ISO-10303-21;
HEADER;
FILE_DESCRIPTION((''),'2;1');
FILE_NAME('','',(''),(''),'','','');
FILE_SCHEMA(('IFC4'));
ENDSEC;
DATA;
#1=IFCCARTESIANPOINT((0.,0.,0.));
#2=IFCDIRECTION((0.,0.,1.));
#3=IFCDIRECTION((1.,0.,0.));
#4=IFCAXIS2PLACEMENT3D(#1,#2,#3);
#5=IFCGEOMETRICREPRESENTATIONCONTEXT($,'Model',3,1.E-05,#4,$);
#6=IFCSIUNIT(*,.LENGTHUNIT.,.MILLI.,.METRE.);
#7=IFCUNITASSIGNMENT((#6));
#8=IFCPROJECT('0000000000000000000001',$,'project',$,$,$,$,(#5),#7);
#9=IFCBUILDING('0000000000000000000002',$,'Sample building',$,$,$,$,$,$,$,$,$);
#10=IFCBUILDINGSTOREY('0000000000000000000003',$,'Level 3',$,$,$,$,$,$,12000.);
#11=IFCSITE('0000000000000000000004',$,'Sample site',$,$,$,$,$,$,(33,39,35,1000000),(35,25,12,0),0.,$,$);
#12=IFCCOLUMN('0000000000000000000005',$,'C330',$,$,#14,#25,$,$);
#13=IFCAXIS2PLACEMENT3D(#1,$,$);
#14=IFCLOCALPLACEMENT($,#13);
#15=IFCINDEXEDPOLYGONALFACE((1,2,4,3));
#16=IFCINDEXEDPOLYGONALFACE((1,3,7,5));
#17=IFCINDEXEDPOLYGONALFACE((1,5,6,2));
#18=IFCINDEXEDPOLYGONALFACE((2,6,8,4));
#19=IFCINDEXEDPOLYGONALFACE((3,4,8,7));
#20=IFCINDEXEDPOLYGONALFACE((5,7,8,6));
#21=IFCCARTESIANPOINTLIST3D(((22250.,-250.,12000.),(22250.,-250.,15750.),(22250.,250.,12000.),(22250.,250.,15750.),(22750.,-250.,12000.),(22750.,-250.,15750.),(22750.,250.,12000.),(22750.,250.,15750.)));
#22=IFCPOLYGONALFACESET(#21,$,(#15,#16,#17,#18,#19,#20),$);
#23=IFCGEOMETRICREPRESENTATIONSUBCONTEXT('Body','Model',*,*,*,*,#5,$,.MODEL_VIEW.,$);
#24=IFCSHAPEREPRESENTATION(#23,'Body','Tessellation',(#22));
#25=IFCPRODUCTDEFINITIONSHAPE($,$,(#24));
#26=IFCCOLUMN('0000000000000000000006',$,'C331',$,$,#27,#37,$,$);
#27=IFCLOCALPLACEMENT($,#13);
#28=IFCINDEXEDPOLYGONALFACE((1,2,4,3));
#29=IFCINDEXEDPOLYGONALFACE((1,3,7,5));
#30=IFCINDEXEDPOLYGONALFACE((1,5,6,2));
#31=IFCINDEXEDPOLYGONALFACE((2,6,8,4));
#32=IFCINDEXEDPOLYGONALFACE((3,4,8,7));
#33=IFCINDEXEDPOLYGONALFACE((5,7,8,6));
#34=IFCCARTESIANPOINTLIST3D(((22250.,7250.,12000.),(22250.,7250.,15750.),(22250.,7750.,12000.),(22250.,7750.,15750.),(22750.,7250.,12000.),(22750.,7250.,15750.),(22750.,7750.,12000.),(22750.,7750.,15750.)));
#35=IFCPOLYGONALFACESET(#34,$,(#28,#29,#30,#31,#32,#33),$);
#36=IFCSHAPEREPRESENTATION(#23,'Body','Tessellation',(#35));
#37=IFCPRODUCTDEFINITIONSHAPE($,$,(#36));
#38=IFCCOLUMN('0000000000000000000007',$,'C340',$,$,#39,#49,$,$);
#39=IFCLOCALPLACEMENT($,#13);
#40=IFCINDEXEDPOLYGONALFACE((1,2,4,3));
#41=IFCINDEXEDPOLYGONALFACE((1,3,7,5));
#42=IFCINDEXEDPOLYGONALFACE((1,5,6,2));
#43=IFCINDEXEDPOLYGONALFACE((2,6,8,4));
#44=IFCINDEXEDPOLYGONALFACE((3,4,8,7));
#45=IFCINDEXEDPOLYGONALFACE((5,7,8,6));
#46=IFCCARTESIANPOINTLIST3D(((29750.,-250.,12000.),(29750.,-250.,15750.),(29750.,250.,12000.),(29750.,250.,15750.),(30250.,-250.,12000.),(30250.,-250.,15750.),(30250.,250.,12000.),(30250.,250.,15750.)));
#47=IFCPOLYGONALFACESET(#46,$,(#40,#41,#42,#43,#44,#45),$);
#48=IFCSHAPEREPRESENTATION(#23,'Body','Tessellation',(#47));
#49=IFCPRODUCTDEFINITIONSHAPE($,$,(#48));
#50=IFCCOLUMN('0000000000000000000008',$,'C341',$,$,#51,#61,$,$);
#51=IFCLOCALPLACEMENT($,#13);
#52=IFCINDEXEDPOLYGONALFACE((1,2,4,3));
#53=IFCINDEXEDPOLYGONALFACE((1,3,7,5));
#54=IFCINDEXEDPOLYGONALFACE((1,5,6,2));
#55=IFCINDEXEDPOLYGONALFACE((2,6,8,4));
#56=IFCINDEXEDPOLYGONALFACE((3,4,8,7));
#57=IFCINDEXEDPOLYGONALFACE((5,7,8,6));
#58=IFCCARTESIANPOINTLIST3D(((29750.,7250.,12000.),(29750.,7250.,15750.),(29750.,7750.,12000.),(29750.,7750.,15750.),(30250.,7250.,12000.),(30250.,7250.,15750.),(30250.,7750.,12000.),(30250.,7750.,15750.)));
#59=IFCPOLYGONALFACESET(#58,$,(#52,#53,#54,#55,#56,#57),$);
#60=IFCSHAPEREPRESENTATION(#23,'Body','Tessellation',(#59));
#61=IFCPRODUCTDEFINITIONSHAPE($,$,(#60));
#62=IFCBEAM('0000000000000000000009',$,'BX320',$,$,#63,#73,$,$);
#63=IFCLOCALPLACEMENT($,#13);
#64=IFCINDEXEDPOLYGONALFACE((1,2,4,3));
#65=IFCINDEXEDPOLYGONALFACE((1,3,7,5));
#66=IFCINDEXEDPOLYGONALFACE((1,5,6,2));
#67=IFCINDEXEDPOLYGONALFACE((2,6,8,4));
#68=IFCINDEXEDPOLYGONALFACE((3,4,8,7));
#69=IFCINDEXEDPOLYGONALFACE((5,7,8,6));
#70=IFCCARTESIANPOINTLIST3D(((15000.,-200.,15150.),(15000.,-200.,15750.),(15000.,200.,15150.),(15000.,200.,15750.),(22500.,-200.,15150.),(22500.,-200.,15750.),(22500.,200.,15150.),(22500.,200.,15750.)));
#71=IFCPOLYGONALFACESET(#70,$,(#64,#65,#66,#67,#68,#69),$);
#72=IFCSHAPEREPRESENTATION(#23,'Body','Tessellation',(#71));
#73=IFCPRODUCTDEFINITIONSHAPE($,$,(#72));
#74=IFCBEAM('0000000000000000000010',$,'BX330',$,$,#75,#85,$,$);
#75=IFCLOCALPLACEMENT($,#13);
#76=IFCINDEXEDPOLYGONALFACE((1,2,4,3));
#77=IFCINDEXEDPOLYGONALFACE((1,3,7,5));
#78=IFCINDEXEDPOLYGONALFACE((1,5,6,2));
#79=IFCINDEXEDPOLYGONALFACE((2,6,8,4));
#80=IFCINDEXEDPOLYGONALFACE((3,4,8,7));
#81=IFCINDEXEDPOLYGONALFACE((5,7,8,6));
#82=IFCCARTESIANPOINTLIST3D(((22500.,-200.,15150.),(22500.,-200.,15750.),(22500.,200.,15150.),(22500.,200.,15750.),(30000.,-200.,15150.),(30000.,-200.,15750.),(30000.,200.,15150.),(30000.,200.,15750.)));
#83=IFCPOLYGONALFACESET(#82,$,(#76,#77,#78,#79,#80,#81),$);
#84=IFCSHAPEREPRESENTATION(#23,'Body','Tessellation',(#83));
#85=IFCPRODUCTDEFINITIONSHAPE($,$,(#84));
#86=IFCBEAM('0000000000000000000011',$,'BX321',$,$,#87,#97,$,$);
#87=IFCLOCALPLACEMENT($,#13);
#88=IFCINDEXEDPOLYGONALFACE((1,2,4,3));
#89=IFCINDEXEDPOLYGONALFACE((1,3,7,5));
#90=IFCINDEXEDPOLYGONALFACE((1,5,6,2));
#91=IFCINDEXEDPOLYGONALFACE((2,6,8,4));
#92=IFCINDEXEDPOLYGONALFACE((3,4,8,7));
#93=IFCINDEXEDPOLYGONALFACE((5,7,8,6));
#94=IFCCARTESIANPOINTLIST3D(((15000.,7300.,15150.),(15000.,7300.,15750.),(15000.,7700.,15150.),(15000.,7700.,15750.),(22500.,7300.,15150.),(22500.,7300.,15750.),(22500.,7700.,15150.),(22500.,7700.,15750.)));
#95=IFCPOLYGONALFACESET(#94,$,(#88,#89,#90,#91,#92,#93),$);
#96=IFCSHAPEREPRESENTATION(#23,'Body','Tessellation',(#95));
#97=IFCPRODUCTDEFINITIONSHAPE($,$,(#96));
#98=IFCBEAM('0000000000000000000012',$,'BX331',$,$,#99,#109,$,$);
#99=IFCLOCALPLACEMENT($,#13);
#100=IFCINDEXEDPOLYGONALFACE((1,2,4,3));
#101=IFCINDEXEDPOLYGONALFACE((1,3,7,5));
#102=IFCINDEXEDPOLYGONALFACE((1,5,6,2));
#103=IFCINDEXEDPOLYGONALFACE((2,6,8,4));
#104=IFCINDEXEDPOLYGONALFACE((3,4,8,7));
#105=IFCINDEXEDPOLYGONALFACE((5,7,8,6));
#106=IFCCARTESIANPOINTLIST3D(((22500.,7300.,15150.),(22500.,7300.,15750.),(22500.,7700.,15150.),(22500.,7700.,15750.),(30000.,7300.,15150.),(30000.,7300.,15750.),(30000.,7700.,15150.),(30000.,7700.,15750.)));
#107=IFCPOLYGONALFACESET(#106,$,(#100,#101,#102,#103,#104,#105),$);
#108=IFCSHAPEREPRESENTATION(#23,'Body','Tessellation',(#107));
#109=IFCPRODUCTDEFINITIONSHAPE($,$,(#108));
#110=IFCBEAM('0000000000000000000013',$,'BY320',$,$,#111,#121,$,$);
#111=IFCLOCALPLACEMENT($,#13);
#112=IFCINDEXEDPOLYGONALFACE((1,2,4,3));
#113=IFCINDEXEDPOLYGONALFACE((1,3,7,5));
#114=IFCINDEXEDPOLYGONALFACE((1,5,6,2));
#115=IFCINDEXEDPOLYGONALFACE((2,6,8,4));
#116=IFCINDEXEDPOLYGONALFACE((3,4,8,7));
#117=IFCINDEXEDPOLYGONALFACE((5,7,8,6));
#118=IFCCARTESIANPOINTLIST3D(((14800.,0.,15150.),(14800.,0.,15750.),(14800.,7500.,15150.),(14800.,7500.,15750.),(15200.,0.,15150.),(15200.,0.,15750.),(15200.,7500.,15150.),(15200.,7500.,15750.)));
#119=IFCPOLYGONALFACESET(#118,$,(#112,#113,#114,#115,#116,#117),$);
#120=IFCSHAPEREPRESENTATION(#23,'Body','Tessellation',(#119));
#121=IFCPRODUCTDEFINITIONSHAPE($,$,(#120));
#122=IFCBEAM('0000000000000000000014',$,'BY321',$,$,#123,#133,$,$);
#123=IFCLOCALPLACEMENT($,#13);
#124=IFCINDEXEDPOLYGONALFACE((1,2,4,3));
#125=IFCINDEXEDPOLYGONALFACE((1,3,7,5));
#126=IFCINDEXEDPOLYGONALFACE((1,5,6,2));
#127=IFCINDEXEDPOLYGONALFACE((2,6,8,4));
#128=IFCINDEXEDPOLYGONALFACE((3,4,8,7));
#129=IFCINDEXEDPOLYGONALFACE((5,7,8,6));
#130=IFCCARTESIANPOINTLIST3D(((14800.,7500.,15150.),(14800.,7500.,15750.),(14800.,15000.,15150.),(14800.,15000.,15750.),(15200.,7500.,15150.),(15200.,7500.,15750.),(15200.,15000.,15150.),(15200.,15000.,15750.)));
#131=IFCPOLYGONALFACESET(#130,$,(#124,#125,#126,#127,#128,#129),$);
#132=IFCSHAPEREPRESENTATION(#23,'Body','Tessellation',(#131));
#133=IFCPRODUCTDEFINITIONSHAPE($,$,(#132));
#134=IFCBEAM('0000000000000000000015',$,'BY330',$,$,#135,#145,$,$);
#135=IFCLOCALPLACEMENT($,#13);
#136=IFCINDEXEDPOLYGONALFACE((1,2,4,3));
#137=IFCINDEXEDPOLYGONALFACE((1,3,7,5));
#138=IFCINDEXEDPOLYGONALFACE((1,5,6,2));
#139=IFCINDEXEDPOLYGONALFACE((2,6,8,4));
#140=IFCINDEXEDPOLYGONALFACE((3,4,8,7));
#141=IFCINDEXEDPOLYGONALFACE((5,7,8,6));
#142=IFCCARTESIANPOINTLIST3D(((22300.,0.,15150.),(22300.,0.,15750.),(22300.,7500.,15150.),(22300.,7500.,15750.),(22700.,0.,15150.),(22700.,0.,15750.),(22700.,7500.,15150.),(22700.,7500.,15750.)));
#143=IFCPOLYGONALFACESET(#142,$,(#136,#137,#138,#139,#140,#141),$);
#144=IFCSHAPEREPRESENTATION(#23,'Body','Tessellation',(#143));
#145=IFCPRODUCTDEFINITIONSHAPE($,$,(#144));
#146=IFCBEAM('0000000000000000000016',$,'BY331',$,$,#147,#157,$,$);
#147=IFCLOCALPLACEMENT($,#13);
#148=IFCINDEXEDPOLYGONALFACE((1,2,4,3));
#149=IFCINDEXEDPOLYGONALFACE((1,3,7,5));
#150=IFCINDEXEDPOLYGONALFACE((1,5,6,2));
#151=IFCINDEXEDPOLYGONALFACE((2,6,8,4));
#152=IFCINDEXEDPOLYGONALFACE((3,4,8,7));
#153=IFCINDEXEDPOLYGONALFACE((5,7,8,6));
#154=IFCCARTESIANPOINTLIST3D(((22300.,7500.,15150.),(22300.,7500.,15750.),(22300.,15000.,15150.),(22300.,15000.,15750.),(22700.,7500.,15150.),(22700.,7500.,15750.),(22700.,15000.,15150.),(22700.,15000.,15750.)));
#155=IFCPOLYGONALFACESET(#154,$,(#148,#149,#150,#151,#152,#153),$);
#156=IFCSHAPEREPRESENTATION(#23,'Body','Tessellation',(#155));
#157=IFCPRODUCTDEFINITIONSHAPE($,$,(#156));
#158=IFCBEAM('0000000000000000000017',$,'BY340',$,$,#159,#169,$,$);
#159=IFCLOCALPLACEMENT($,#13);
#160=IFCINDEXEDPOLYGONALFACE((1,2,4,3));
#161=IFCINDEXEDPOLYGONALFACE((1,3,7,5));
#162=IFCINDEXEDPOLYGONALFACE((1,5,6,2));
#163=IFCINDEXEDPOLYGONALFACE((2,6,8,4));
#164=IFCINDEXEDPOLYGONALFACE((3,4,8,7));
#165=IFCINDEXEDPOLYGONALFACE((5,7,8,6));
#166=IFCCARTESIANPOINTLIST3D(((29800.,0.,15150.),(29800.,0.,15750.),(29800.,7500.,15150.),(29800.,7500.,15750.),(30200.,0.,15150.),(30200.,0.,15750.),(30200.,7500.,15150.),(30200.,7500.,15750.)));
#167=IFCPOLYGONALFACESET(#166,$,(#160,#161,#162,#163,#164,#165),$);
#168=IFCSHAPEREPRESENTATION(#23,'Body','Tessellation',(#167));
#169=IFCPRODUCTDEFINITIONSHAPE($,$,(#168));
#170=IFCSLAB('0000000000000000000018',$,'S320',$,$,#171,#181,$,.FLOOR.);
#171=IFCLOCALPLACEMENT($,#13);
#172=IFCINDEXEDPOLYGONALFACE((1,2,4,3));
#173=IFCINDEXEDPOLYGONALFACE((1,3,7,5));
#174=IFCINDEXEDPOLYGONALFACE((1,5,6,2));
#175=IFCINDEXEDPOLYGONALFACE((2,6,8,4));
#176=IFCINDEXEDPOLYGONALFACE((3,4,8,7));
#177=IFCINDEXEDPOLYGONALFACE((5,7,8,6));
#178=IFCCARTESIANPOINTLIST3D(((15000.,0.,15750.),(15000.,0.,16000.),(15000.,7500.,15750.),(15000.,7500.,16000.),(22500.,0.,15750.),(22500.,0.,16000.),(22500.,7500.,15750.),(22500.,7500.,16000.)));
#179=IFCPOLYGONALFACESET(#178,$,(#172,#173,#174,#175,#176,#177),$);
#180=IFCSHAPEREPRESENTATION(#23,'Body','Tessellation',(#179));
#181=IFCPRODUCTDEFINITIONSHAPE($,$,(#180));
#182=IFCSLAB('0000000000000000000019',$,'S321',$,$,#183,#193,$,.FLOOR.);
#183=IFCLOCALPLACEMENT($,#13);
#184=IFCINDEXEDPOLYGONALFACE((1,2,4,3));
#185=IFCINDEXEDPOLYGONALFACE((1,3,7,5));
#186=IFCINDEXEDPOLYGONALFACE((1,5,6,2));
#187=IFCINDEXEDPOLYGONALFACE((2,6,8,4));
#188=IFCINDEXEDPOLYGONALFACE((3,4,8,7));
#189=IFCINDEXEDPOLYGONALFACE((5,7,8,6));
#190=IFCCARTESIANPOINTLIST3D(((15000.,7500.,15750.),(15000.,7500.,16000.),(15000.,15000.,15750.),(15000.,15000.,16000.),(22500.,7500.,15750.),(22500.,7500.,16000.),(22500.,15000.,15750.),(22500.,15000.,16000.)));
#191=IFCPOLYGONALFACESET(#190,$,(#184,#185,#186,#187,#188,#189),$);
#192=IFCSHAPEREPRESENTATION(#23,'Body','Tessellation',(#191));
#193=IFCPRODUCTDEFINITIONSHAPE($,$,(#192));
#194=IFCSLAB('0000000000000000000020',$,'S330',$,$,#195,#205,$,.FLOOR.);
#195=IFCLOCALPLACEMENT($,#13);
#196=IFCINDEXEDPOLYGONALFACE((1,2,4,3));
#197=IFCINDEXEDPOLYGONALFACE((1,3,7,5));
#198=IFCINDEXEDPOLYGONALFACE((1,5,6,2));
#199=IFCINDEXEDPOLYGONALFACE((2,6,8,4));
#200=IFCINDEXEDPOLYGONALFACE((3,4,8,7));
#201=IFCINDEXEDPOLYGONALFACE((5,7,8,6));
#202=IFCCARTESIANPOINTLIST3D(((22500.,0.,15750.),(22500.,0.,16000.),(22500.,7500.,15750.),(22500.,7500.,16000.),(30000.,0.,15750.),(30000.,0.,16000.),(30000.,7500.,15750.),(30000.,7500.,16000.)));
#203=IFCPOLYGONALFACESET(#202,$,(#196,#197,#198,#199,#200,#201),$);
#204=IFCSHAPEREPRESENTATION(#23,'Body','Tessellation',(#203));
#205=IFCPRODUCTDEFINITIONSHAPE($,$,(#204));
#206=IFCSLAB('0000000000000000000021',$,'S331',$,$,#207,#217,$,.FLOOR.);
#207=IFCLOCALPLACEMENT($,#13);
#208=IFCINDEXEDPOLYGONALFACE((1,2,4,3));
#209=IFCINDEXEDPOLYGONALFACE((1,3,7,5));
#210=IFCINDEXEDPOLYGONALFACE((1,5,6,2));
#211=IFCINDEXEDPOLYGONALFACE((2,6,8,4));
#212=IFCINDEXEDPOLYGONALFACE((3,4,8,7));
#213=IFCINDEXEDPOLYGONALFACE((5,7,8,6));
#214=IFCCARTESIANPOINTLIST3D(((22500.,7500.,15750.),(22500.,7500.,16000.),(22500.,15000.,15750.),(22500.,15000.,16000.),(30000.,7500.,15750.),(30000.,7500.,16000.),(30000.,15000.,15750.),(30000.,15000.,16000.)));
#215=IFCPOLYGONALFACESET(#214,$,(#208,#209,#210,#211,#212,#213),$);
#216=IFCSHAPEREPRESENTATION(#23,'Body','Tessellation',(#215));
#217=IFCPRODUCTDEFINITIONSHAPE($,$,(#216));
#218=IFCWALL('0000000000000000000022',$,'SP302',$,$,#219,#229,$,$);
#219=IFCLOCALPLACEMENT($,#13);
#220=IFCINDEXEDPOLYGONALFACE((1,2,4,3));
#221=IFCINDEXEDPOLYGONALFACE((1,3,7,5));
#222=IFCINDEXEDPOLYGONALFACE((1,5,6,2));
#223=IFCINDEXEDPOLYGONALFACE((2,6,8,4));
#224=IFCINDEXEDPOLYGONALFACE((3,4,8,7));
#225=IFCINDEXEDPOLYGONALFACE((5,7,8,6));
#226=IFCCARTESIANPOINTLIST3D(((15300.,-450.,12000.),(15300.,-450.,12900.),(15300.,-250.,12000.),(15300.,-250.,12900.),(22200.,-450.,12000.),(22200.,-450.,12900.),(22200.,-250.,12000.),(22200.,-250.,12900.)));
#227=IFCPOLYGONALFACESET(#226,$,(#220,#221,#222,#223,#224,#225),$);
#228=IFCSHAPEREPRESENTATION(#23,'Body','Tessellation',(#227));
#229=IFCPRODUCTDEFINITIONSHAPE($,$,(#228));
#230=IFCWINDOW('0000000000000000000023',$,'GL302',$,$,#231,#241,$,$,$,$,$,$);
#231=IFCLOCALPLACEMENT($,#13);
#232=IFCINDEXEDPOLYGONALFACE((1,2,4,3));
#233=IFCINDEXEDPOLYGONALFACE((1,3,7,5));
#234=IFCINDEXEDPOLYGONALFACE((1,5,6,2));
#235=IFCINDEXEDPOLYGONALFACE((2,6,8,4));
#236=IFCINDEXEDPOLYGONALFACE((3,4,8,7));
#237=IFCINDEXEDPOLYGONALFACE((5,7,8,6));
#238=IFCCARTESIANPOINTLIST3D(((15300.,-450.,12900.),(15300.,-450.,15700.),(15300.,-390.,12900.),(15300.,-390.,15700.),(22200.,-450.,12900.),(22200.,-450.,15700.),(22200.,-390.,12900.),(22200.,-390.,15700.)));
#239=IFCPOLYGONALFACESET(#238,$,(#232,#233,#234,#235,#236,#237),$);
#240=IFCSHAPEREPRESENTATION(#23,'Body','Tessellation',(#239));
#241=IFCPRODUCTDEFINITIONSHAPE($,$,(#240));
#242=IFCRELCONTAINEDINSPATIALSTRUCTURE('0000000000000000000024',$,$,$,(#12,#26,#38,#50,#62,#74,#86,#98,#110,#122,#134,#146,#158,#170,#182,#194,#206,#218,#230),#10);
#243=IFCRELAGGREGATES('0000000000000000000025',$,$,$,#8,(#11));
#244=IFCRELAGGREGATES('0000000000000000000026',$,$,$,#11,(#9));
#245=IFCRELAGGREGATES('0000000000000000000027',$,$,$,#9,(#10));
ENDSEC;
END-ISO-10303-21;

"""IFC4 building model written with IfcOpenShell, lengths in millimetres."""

from ifc_helpers import new_model, si_unit, frame, origin_with_axes, place, context, subcontext, project, spatial, indexed_curve, outline, extrude, element, save


model = new_model("IFC4")

# Units and contexts
model_context = context("Model", 3, precision=1e-05, world=origin_with_axes())
body_context = subcontext(model_context, "Body", "Model", "MODEL_VIEW")
ifc_project = project(units=[si_unit("LENGTHUNIT", "METRE", prefix="MILLI")], contexts=[model_context])

# Site, building, storey
site = spatial("IfcSite", under=ifc_project, Name="Sample site", RefLatitude=(33, 39, 35, 1000000), RefLongitude=(35, 25, 12, 0), RefElevation=0.0)
building = spatial("IfcBuilding", under=site, Name="Sample building")
storey = spatial("IfcBuildingStorey", under=building, Name="Level 3", Elevation=12000.0)

# Columns
for number, where, z_axis, x_axis, name in (
    (1, (22250.0, -250.0, 12000.0), (0.0, 0.0, 1.0), (1.0, 0.0, 0.0), "C330"),
    (2, (22250.0, 7250.0, 12000.0), (0.0, 0.0, 1.0), (1.0, 0.0, 0.0), "C331"),
    (3, (29750.0, -250.0, 12000.0), (0.0, 0.0, 1.0), (1.0, 0.0, 0.0), "C340"),
    (4, (29750.0, 7250.0, 12000.0), (0.0, 0.0, 1.0), (1.0, 0.0, 0.0), "C341"),
):
    element("IfcColumn", number, at=place(None, frame(where, z_axis=z_axis, x_axis=x_axis)), inside=storey, Name=name, context=body_context, shape_type="SweptSolid", body=[
        extrude(outline(indexed_curve([(0.0, 0.0), (0.0, 500.0), (500.0, 500.0), (500.0, 0.0), (0.0, 0.0)], self_intersect=False)), origin_with_axes(), (0.0, 0.0, 1.0), 3750.0),
    ])

# Beams
for number, where, z_axis, x_axis, name in (
    (5, (15000.0, -200.0, 15150.0), (0.0, 0.0, 1.0), (1.0, 0.0, 0.0), "BX320"),
    (6, (22500.0, -200.0, 15150.0), (0.0, 0.0, 1.0), (1.0, 0.0, 0.0), "BX330"),
    (7, (15000.0, 7300.0, 15150.0), (0.0, 0.0, 1.0), (1.0, 0.0, 0.0), "BX321"),
    (8, (22500.0, 7300.0, 15150.0), (0.0, 0.0, 1.0), (1.0, 0.0, 0.0), "BX331"),
    (9, (15200.0, 0.0, 15150.0), (0.0, 0.0, 1.0), (0.0, 1.0, 0.0), "BY320"),
    (10, (15200.0, 7500.0, 15150.0), (0.0, 0.0, 1.0), (0.0, 1.0, 0.0), "BY321"),
    (11, (22700.0, 0.0, 15150.0), (0.0, 0.0, 1.0), (0.0, 1.0, 0.0), "BY330"),
    (12, (22700.0, 7500.0, 15150.0), (0.0, 0.0, 1.0), (0.0, 1.0, 0.0), "BY331"),
    (13, (30200.0, 0.0, 15150.0), (0.0, 0.0, 1.0), (0.0, 1.0, 0.0), "BY340"),
):
    element("IfcBeam", number, at=place(None, frame(where, z_axis=z_axis, x_axis=x_axis)), inside=storey, Name=name, context=body_context, shape_type="SweptSolid", body=[
        extrude(outline(indexed_curve([(0.0, 0.0), (0.0, 400.0), (7500.0, 400.0), (7500.0, 0.0), (0.0, 0.0)], self_intersect=False)), origin_with_axes(), (0.0, 0.0, 1.0), 600.0),
    ])

# Slabs
for number, where, z_axis, x_axis, name in (
    (14, (15000.0, 0.0, 15750.0), (0.0, 0.0, 1.0), (1.0, 0.0, 0.0), "S320"),
    (15, (15000.0, 7500.0, 15750.0), (0.0, 0.0, 1.0), (1.0, 0.0, 0.0), "S321"),
    (16, (22500.0, 0.0, 15750.0), (0.0, 0.0, 1.0), (1.0, 0.0, 0.0), "S330"),
    (17, (22500.0, 7500.0, 15750.0), (0.0, 0.0, 1.0), (1.0, 0.0, 0.0), "S331"),
):
    element("IfcSlab", number, at=place(None, frame(where, z_axis=z_axis, x_axis=x_axis)), inside=storey, Name=name, PredefinedType="FLOOR", context=body_context, shape_type="SweptSolid", body=[
        extrude(outline(indexed_curve([(0.0, 0.0), (0.0, 7500.0), (7500.0, 7500.0), (7500.0, 0.0), (0.0, 0.0)], self_intersect=False)), origin_with_axes(), (0.0, 0.0, 1.0), 250.0),
    ])

# Wall
wall_1_placement = place(None, frame((15300.0, -450.0, 12000.0), z_axis=(0.0, 0.0, 1.0), x_axis=(1.0, 0.0, 0.0)))
element("IfcWall", 18, at=wall_1_placement, inside=storey, Name="SP302", context=body_context, shape_type="SweptSolid", body=[
    extrude(outline(indexed_curve([(0.0, 0.0), (0.0, 200.0), (6900.0, 200.0), (6900.0, 0.0), (0.0, 0.0)], self_intersect=False)), origin_with_axes(), (0.0, 0.0, 1.0), 900.0),
])

# Window
window_1_placement = place(None, frame((15300.0, -450.0, 12900.0), z_axis=(0.0, 0.0, 1.0), x_axis=(1.0, 0.0, 0.0)))
element("IfcWindow", 19, at=window_1_placement, inside=storey, Name="GL302", context=body_context, shape_type="SweptSolid", body=[
    extrude(outline(indexed_curve([(0.0, 0.0), (0.0, 60.0), (6900.0, 60.0), (6900.0, 0.0), (0.0, 0.0)], self_intersect=False)), origin_with_axes(), (0.0, 0.0, 1.0), 2800.0),
])

save(model, "model.ifc")
